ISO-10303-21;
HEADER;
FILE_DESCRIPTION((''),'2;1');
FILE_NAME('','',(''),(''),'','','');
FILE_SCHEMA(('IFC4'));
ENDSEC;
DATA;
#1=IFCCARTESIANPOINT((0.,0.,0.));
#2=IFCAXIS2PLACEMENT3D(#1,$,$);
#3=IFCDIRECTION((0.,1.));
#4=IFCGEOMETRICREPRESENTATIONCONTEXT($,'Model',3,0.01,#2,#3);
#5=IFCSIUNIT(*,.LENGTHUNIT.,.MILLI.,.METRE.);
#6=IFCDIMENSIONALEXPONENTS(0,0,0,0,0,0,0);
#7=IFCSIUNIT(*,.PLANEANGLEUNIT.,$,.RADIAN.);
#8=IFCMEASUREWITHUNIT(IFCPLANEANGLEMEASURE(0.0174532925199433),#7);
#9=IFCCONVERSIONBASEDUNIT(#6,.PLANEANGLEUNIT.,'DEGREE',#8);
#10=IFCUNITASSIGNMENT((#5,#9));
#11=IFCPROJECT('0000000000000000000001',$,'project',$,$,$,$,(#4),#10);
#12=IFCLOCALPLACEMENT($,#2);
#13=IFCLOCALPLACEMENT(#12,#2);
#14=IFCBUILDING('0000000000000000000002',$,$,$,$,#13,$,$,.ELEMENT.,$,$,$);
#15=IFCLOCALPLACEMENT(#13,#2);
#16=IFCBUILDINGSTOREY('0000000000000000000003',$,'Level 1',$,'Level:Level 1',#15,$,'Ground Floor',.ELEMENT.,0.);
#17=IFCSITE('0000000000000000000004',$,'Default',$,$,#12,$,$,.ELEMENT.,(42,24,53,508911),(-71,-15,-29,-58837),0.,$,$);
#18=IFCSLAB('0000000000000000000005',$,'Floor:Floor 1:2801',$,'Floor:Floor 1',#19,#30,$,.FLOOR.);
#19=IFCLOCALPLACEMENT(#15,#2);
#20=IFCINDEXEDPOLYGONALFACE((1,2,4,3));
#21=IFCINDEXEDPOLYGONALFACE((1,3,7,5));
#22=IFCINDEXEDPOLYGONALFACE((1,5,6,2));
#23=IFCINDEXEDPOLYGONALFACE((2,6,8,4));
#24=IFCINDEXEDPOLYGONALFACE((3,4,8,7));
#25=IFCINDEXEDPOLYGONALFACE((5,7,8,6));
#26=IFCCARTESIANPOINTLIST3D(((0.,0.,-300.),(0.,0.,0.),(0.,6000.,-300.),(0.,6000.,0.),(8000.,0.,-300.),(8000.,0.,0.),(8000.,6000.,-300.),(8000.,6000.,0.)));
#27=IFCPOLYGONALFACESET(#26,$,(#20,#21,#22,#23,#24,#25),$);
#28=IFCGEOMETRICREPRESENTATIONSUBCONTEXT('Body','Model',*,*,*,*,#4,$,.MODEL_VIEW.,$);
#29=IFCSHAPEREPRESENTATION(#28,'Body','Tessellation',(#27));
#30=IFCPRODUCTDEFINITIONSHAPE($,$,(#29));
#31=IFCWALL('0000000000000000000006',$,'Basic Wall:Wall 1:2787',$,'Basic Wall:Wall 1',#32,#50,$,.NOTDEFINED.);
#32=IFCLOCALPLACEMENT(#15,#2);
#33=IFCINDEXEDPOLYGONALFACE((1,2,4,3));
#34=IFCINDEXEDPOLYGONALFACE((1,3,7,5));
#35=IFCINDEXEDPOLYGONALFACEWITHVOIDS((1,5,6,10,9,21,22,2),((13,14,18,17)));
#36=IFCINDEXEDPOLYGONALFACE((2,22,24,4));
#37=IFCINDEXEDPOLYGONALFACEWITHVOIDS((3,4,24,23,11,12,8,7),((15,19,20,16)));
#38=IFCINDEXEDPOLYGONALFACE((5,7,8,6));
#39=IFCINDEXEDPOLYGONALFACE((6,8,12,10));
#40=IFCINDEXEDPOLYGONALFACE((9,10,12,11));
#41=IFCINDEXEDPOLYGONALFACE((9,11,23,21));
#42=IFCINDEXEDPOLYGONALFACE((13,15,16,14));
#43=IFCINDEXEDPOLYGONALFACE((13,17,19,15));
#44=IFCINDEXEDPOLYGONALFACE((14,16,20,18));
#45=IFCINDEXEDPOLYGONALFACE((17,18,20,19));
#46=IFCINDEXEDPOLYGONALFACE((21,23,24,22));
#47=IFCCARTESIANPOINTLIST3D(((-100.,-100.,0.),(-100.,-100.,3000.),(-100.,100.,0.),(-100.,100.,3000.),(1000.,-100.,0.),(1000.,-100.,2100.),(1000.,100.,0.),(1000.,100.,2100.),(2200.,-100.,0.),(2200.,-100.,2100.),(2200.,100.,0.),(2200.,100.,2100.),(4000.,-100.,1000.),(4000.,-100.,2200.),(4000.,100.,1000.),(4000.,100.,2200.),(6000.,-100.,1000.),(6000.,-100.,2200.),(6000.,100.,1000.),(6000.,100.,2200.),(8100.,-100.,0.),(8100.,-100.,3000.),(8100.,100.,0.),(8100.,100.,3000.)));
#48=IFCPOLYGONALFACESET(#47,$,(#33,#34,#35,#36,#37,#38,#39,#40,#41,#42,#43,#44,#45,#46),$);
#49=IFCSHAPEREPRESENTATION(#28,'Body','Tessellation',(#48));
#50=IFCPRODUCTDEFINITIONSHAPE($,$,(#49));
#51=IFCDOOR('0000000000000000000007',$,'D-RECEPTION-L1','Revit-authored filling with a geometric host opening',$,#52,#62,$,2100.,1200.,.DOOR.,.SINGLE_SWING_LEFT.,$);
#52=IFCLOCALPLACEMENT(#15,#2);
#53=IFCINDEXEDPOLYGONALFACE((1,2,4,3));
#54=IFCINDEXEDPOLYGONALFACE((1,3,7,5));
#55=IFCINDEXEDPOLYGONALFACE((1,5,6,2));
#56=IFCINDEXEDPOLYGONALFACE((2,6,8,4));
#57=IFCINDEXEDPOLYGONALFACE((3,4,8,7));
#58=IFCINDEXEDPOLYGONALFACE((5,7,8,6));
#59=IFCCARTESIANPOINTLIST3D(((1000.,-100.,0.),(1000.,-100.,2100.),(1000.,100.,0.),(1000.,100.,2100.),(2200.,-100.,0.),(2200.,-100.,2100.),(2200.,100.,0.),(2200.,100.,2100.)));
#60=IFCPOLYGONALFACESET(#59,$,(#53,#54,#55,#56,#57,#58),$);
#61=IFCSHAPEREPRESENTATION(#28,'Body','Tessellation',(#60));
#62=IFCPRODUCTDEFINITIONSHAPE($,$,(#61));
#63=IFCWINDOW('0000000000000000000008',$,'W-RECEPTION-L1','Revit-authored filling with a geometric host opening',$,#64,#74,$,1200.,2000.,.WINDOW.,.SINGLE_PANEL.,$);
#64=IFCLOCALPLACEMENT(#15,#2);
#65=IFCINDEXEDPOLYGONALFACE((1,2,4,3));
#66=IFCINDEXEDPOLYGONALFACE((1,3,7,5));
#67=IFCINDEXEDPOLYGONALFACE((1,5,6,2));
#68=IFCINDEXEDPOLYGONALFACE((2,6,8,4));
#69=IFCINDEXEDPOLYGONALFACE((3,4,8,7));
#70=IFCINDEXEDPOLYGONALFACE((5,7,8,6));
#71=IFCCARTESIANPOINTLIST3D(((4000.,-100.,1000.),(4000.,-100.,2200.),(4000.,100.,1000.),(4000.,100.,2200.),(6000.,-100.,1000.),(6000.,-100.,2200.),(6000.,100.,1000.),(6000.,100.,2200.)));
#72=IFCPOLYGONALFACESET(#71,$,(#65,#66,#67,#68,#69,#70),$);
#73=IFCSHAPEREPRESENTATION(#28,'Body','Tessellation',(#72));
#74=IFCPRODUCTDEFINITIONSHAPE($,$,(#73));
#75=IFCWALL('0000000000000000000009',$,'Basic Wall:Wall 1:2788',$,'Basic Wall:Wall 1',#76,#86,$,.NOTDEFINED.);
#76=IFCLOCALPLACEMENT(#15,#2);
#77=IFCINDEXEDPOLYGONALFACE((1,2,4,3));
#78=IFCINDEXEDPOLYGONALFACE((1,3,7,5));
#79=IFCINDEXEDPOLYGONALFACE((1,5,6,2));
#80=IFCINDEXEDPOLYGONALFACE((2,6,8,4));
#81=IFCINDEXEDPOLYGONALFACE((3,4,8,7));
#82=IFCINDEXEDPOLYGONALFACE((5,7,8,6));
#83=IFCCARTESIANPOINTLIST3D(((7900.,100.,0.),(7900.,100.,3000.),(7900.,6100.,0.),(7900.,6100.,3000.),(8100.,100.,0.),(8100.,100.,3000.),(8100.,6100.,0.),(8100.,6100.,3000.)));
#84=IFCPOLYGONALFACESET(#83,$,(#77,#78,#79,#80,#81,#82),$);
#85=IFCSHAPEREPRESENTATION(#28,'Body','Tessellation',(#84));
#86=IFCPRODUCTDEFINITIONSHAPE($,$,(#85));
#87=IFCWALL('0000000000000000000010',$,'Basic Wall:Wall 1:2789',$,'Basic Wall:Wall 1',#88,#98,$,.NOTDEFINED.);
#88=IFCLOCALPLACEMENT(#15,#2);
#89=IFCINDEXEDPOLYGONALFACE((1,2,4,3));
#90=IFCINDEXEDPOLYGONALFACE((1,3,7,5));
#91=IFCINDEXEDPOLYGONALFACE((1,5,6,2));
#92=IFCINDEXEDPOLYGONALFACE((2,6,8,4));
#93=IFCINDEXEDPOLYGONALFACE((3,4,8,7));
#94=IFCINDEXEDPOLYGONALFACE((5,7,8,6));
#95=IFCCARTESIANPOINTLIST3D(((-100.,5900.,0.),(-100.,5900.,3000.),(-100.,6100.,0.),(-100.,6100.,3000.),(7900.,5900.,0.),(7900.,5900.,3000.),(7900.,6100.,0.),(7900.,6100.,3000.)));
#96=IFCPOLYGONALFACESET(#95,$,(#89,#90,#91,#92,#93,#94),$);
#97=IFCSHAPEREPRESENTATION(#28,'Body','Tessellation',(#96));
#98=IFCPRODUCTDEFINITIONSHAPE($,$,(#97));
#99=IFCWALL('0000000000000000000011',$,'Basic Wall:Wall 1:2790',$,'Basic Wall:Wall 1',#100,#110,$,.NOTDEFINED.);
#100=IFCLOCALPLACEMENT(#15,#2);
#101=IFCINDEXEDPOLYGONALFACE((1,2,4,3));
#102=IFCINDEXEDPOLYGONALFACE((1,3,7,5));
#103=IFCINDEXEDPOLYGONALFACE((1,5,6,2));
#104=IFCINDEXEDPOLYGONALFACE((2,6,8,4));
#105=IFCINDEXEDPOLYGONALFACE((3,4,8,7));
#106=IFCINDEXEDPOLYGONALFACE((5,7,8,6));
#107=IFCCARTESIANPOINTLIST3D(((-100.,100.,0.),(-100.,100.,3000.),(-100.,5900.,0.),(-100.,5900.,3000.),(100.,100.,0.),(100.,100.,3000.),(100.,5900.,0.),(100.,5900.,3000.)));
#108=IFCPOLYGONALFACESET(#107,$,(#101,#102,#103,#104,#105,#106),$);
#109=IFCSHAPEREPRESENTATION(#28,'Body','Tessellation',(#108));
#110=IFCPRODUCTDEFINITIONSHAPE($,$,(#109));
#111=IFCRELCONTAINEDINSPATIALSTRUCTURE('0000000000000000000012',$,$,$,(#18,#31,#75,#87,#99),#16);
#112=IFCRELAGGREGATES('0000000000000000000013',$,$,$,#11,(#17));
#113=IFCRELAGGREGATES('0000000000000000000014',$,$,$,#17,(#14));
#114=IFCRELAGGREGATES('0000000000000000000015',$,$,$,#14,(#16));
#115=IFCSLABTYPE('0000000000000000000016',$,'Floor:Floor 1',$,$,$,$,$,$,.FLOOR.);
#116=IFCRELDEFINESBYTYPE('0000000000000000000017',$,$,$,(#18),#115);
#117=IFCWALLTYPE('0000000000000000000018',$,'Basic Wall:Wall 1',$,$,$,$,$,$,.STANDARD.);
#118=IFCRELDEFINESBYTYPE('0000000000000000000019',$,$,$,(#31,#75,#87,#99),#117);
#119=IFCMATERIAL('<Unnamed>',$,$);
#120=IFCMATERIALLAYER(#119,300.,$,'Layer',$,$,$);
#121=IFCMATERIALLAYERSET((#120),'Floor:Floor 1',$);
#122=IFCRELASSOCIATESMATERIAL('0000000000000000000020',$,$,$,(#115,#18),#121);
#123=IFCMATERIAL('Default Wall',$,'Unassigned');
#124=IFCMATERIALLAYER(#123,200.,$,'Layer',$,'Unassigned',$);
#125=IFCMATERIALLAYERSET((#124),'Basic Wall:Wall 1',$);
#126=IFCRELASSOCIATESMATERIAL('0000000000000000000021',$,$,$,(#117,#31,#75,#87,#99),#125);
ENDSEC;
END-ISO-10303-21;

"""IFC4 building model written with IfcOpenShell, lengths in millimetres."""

from ifc_helpers import new_model, entity, si_unit, converted_unit, direction, frame, frame_2d, origin, origin_2d, origin_2d_with_axis, place, context, subcontext, project, spatial, rectangle, extrude, material, layer, layer_set, layer_usage, type_object, element, fill, save


model = new_model("IFC4")

# Units and contexts
model_context = context("Model", 3, precision=0.01, world=origin(), true_north=direction((0.0, 1.0)))
body_context = subcontext(model_context, "Body", "Model", "MODEL_VIEW")
ifc_project = project(units=[si_unit("LENGTHUNIT", "METRE", prefix="MILLI"), converted_unit("PLANEANGLEUNIT", "DEGREE", entity("IfcPlaneAngleMeasure", 0.0174532925199433), si_unit("PLANEANGLEUNIT", "RADIAN"), dimensions=[0, 0, 0, 0, 0, 0, 0])], contexts=[model_context])

# Site, building, storey
site_placement = place(None, origin())
site = spatial("IfcSite", under=ifc_project, at=site_placement, Name="Default", CompositionType="ELEMENT", RefLatitude=(42, 24, 53, 508911), RefLongitude=(-71, -15, -29, -58837), RefElevation=0.0)
building_placement = place(site_placement, origin())
building = spatial("IfcBuilding", under=site, at=building_placement, CompositionType="ELEMENT")
storey_placement = place(building_placement, origin())
storey = spatial("IfcBuildingStorey", under=building, at=storey_placement, Name="Level 1", ObjectType="Level:Level 1", LongName="Ground Floor", CompositionType="ELEMENT", Elevation=0.0)

# Slab
ifc_material_1 = material(Name="<Unnamed>")
ifc_layer_1 = layer(ifc_material_1, 300.0, Name="Layer")
ifc_layer_set_1 = layer_set([ifc_layer_1], Name="Floor:Floor 1")
ifc_layer_usage_1 = layer_usage(ifc_layer_set_1, "AXIS3", "POSITIVE", 0.0)
slab_type = type_object("IfcSlabType", Name="Floor:Floor 1", PredefinedType="FLOOR", material=ifc_layer_set_1)
slab_placement = place(storey_placement, origin())
element("IfcSlab", 1, at=slab_placement, inside=storey, type_object=slab_type, material=ifc_layer_usage_1, Name="Floor:Floor 1:2801", ObjectType="Floor:Floor 1", PredefinedType="FLOOR", context=body_context, shape_type="SweptSolid", body=[
    extrude(rectangle(XDim=6000.0, YDim=8000.0, at=origin_2d_with_axis()), frame((4000.0, 3000.0, 0.0), z_axis=(0.0, 0.0, -1.0), x_axis=(0.0, 1.0, 0.0)), (0.0, 0.0, 1.0), 300.0),
])

# Wall, openings, door, window
ifc_material_2 = material(Name="Default Wall", Category="Unassigned")
ifc_layer_2 = layer(ifc_material_2, 200.0, Name="Layer", Category="Unassigned")
ifc_layer_set_2 = layer_set([ifc_layer_2], Name="Basic Wall:Wall 1")
ifc_layer_usage_2 = layer_usage(ifc_layer_set_2, "AXIS2", "NEGATIVE", 100.0)
wall_type = type_object("IfcWallType", Name="Basic Wall:Wall 1", PredefinedType="STANDARD", material=ifc_layer_set_2)
wall_1_placement = place(storey_placement, frame((-100.0, 0.0, 0.0)))
wall_1 = element("IfcWall", 2, at=wall_1_placement, inside=storey, type_object=wall_type, material=ifc_layer_usage_2, Name="Basic Wall:Wall 1:2787", ObjectType="Basic Wall:Wall 1", PredefinedType="NOTDEFINED", context=body_context, shape_type="SweptSolid", body=[
    extrude(rectangle(XDim=8200.0, YDim=200.0, at=frame_2d((4100.0, 0.0), x_axis=(-1.0, 0.0))), origin(), (0.0, 0.0, 1.0), 3000.0),
])
opening_1_placement = place(storey_placement, frame((1000.0, -100.0, 0.0)))
opening_1 = element("IfcOpeningElement", 3, at=opening_1_placement, cuts=wall_1, PredefinedType="OPENING", context=body_context, shape_type="SweptSolid", body=[
    extrude(rectangle(XDim=1200.0, YDim=200.0, at=origin_2d()), frame((600.0, 100.0, 0.0)), (0.0, 0.0, 1.0), 2100.0),
])
opening_2_placement = place(storey_placement, frame((4000.0, -100.0, 1000.0)))
opening_2 = element("IfcOpeningElement", 4, at=opening_2_placement, cuts=wall_1, PredefinedType="OPENING", context=body_context, shape_type="SweptSolid", body=[
    extrude(rectangle(XDim=2000.0, YDim=200.0, at=origin_2d()), frame((1000.0, 100.0, 0.0)), (0.0, 0.0, 1.0), 1200.0),
])
door_placement = place(storey_placement, frame((1000.0, -100.0, 0.0)))
door = element("IfcDoor", 5, at=door_placement, Name="D-RECEPTION-L1", Description="Revit-authored filling with a geometric host opening", OperationType="SINGLE_SWING_LEFT", OverallHeight=2100.0, OverallWidth=1200.0, PredefinedType="DOOR", context=body_context, shape_type="SweptSolid", body=[
    extrude(rectangle(XDim=1200.0, YDim=200.0, at=origin_2d()), frame((600.0, 100.0, 0.0)), (0.0, 0.0, 1.0), 2100.0),
])
fill(opening_1, door)
window_placement = place(storey_placement, frame((4000.0, -100.0, 1000.0)))
window = element("IfcWindow", 6, at=window_placement, Name="W-RECEPTION-L1", Description="Revit-authored filling with a geometric host opening", OverallHeight=1200.0, OverallWidth=2000.0, PartitioningType="SINGLE_PANEL", PredefinedType="WINDOW", context=body_context, shape_type="SweptSolid", body=[
    extrude(rectangle(XDim=2000.0, YDim=200.0, at=origin_2d()), frame((1000.0, 100.0, 0.0)), (0.0, 0.0, 1.0), 1200.0),
])
fill(opening_2, window)

# Walls
ifc_layer_usage_3 = layer_usage(ifc_layer_set_2, "AXIS2", "NEGATIVE", 100.0)
wall_2_placement = place(storey_placement, frame((8000.0, 100.0, 0.0), z_axis=(0.0, 0.0, 1.0), x_axis=(0.0, 1.0, 0.0)))
element("IfcWall", 7, at=wall_2_placement, inside=storey, type_object=wall_type, material=ifc_layer_usage_3, Name="Basic Wall:Wall 1:2788", ObjectType="Basic Wall:Wall 1", PredefinedType="NOTDEFINED", context=body_context, shape_type="SweptSolid", body=[
    extrude(rectangle(XDim=6000.0, YDim=200.0, at=frame_2d((3000.0, 0.0), x_axis=(-1.0, 0.0))), origin(), (0.0, 0.0, 1.0), 3000.0),
])
ifc_layer_usage_4 = layer_usage(ifc_layer_set_2, "AXIS2", "NEGATIVE", 100.0)
wall_3_placement = place(storey_placement, frame((7900.0, 6000.0, 0.0), z_axis=(0.0, 0.0, 1.0), x_axis=(-1.0, 0.0, 0.0)))
element("IfcWall", 8, at=wall_3_placement, inside=storey, type_object=wall_type, material=ifc_layer_usage_4, Name="Basic Wall:Wall 1:2789", ObjectType="Basic Wall:Wall 1", PredefinedType="NOTDEFINED", context=body_context, shape_type="SweptSolid", body=[
    extrude(rectangle(XDim=8000.0, YDim=200.0, at=frame_2d((4000.0, 0.0), x_axis=(-1.0, 0.0))), origin(), (0.0, 0.0, 1.0), 3000.0),
])
ifc_layer_usage_5 = layer_usage(ifc_layer_set_2, "AXIS2", "NEGATIVE", 100.0)
wall_4_placement = place(storey_placement, frame((0.0, 5900.0, 0.0), z_axis=(0.0, 0.0, 1.0), x_axis=(0.0, -1.0, 0.0)))
element("IfcWall", 9, at=wall_4_placement, inside=storey, type_object=wall_type, material=ifc_layer_usage_5, Name="Basic Wall:Wall 1:2790", ObjectType="Basic Wall:Wall 1", PredefinedType="NOTDEFINED", context=body_context, shape_type="SweptSolid", body=[
    extrude(rectangle(XDim=5800.0, YDim=200.0, at=frame_2d((2900.0, 0.0), x_axis=(-1.0, 0.0))), origin(), (0.0, 0.0, 1.0), 3000.0),
])

save(model, "model.ifc")
